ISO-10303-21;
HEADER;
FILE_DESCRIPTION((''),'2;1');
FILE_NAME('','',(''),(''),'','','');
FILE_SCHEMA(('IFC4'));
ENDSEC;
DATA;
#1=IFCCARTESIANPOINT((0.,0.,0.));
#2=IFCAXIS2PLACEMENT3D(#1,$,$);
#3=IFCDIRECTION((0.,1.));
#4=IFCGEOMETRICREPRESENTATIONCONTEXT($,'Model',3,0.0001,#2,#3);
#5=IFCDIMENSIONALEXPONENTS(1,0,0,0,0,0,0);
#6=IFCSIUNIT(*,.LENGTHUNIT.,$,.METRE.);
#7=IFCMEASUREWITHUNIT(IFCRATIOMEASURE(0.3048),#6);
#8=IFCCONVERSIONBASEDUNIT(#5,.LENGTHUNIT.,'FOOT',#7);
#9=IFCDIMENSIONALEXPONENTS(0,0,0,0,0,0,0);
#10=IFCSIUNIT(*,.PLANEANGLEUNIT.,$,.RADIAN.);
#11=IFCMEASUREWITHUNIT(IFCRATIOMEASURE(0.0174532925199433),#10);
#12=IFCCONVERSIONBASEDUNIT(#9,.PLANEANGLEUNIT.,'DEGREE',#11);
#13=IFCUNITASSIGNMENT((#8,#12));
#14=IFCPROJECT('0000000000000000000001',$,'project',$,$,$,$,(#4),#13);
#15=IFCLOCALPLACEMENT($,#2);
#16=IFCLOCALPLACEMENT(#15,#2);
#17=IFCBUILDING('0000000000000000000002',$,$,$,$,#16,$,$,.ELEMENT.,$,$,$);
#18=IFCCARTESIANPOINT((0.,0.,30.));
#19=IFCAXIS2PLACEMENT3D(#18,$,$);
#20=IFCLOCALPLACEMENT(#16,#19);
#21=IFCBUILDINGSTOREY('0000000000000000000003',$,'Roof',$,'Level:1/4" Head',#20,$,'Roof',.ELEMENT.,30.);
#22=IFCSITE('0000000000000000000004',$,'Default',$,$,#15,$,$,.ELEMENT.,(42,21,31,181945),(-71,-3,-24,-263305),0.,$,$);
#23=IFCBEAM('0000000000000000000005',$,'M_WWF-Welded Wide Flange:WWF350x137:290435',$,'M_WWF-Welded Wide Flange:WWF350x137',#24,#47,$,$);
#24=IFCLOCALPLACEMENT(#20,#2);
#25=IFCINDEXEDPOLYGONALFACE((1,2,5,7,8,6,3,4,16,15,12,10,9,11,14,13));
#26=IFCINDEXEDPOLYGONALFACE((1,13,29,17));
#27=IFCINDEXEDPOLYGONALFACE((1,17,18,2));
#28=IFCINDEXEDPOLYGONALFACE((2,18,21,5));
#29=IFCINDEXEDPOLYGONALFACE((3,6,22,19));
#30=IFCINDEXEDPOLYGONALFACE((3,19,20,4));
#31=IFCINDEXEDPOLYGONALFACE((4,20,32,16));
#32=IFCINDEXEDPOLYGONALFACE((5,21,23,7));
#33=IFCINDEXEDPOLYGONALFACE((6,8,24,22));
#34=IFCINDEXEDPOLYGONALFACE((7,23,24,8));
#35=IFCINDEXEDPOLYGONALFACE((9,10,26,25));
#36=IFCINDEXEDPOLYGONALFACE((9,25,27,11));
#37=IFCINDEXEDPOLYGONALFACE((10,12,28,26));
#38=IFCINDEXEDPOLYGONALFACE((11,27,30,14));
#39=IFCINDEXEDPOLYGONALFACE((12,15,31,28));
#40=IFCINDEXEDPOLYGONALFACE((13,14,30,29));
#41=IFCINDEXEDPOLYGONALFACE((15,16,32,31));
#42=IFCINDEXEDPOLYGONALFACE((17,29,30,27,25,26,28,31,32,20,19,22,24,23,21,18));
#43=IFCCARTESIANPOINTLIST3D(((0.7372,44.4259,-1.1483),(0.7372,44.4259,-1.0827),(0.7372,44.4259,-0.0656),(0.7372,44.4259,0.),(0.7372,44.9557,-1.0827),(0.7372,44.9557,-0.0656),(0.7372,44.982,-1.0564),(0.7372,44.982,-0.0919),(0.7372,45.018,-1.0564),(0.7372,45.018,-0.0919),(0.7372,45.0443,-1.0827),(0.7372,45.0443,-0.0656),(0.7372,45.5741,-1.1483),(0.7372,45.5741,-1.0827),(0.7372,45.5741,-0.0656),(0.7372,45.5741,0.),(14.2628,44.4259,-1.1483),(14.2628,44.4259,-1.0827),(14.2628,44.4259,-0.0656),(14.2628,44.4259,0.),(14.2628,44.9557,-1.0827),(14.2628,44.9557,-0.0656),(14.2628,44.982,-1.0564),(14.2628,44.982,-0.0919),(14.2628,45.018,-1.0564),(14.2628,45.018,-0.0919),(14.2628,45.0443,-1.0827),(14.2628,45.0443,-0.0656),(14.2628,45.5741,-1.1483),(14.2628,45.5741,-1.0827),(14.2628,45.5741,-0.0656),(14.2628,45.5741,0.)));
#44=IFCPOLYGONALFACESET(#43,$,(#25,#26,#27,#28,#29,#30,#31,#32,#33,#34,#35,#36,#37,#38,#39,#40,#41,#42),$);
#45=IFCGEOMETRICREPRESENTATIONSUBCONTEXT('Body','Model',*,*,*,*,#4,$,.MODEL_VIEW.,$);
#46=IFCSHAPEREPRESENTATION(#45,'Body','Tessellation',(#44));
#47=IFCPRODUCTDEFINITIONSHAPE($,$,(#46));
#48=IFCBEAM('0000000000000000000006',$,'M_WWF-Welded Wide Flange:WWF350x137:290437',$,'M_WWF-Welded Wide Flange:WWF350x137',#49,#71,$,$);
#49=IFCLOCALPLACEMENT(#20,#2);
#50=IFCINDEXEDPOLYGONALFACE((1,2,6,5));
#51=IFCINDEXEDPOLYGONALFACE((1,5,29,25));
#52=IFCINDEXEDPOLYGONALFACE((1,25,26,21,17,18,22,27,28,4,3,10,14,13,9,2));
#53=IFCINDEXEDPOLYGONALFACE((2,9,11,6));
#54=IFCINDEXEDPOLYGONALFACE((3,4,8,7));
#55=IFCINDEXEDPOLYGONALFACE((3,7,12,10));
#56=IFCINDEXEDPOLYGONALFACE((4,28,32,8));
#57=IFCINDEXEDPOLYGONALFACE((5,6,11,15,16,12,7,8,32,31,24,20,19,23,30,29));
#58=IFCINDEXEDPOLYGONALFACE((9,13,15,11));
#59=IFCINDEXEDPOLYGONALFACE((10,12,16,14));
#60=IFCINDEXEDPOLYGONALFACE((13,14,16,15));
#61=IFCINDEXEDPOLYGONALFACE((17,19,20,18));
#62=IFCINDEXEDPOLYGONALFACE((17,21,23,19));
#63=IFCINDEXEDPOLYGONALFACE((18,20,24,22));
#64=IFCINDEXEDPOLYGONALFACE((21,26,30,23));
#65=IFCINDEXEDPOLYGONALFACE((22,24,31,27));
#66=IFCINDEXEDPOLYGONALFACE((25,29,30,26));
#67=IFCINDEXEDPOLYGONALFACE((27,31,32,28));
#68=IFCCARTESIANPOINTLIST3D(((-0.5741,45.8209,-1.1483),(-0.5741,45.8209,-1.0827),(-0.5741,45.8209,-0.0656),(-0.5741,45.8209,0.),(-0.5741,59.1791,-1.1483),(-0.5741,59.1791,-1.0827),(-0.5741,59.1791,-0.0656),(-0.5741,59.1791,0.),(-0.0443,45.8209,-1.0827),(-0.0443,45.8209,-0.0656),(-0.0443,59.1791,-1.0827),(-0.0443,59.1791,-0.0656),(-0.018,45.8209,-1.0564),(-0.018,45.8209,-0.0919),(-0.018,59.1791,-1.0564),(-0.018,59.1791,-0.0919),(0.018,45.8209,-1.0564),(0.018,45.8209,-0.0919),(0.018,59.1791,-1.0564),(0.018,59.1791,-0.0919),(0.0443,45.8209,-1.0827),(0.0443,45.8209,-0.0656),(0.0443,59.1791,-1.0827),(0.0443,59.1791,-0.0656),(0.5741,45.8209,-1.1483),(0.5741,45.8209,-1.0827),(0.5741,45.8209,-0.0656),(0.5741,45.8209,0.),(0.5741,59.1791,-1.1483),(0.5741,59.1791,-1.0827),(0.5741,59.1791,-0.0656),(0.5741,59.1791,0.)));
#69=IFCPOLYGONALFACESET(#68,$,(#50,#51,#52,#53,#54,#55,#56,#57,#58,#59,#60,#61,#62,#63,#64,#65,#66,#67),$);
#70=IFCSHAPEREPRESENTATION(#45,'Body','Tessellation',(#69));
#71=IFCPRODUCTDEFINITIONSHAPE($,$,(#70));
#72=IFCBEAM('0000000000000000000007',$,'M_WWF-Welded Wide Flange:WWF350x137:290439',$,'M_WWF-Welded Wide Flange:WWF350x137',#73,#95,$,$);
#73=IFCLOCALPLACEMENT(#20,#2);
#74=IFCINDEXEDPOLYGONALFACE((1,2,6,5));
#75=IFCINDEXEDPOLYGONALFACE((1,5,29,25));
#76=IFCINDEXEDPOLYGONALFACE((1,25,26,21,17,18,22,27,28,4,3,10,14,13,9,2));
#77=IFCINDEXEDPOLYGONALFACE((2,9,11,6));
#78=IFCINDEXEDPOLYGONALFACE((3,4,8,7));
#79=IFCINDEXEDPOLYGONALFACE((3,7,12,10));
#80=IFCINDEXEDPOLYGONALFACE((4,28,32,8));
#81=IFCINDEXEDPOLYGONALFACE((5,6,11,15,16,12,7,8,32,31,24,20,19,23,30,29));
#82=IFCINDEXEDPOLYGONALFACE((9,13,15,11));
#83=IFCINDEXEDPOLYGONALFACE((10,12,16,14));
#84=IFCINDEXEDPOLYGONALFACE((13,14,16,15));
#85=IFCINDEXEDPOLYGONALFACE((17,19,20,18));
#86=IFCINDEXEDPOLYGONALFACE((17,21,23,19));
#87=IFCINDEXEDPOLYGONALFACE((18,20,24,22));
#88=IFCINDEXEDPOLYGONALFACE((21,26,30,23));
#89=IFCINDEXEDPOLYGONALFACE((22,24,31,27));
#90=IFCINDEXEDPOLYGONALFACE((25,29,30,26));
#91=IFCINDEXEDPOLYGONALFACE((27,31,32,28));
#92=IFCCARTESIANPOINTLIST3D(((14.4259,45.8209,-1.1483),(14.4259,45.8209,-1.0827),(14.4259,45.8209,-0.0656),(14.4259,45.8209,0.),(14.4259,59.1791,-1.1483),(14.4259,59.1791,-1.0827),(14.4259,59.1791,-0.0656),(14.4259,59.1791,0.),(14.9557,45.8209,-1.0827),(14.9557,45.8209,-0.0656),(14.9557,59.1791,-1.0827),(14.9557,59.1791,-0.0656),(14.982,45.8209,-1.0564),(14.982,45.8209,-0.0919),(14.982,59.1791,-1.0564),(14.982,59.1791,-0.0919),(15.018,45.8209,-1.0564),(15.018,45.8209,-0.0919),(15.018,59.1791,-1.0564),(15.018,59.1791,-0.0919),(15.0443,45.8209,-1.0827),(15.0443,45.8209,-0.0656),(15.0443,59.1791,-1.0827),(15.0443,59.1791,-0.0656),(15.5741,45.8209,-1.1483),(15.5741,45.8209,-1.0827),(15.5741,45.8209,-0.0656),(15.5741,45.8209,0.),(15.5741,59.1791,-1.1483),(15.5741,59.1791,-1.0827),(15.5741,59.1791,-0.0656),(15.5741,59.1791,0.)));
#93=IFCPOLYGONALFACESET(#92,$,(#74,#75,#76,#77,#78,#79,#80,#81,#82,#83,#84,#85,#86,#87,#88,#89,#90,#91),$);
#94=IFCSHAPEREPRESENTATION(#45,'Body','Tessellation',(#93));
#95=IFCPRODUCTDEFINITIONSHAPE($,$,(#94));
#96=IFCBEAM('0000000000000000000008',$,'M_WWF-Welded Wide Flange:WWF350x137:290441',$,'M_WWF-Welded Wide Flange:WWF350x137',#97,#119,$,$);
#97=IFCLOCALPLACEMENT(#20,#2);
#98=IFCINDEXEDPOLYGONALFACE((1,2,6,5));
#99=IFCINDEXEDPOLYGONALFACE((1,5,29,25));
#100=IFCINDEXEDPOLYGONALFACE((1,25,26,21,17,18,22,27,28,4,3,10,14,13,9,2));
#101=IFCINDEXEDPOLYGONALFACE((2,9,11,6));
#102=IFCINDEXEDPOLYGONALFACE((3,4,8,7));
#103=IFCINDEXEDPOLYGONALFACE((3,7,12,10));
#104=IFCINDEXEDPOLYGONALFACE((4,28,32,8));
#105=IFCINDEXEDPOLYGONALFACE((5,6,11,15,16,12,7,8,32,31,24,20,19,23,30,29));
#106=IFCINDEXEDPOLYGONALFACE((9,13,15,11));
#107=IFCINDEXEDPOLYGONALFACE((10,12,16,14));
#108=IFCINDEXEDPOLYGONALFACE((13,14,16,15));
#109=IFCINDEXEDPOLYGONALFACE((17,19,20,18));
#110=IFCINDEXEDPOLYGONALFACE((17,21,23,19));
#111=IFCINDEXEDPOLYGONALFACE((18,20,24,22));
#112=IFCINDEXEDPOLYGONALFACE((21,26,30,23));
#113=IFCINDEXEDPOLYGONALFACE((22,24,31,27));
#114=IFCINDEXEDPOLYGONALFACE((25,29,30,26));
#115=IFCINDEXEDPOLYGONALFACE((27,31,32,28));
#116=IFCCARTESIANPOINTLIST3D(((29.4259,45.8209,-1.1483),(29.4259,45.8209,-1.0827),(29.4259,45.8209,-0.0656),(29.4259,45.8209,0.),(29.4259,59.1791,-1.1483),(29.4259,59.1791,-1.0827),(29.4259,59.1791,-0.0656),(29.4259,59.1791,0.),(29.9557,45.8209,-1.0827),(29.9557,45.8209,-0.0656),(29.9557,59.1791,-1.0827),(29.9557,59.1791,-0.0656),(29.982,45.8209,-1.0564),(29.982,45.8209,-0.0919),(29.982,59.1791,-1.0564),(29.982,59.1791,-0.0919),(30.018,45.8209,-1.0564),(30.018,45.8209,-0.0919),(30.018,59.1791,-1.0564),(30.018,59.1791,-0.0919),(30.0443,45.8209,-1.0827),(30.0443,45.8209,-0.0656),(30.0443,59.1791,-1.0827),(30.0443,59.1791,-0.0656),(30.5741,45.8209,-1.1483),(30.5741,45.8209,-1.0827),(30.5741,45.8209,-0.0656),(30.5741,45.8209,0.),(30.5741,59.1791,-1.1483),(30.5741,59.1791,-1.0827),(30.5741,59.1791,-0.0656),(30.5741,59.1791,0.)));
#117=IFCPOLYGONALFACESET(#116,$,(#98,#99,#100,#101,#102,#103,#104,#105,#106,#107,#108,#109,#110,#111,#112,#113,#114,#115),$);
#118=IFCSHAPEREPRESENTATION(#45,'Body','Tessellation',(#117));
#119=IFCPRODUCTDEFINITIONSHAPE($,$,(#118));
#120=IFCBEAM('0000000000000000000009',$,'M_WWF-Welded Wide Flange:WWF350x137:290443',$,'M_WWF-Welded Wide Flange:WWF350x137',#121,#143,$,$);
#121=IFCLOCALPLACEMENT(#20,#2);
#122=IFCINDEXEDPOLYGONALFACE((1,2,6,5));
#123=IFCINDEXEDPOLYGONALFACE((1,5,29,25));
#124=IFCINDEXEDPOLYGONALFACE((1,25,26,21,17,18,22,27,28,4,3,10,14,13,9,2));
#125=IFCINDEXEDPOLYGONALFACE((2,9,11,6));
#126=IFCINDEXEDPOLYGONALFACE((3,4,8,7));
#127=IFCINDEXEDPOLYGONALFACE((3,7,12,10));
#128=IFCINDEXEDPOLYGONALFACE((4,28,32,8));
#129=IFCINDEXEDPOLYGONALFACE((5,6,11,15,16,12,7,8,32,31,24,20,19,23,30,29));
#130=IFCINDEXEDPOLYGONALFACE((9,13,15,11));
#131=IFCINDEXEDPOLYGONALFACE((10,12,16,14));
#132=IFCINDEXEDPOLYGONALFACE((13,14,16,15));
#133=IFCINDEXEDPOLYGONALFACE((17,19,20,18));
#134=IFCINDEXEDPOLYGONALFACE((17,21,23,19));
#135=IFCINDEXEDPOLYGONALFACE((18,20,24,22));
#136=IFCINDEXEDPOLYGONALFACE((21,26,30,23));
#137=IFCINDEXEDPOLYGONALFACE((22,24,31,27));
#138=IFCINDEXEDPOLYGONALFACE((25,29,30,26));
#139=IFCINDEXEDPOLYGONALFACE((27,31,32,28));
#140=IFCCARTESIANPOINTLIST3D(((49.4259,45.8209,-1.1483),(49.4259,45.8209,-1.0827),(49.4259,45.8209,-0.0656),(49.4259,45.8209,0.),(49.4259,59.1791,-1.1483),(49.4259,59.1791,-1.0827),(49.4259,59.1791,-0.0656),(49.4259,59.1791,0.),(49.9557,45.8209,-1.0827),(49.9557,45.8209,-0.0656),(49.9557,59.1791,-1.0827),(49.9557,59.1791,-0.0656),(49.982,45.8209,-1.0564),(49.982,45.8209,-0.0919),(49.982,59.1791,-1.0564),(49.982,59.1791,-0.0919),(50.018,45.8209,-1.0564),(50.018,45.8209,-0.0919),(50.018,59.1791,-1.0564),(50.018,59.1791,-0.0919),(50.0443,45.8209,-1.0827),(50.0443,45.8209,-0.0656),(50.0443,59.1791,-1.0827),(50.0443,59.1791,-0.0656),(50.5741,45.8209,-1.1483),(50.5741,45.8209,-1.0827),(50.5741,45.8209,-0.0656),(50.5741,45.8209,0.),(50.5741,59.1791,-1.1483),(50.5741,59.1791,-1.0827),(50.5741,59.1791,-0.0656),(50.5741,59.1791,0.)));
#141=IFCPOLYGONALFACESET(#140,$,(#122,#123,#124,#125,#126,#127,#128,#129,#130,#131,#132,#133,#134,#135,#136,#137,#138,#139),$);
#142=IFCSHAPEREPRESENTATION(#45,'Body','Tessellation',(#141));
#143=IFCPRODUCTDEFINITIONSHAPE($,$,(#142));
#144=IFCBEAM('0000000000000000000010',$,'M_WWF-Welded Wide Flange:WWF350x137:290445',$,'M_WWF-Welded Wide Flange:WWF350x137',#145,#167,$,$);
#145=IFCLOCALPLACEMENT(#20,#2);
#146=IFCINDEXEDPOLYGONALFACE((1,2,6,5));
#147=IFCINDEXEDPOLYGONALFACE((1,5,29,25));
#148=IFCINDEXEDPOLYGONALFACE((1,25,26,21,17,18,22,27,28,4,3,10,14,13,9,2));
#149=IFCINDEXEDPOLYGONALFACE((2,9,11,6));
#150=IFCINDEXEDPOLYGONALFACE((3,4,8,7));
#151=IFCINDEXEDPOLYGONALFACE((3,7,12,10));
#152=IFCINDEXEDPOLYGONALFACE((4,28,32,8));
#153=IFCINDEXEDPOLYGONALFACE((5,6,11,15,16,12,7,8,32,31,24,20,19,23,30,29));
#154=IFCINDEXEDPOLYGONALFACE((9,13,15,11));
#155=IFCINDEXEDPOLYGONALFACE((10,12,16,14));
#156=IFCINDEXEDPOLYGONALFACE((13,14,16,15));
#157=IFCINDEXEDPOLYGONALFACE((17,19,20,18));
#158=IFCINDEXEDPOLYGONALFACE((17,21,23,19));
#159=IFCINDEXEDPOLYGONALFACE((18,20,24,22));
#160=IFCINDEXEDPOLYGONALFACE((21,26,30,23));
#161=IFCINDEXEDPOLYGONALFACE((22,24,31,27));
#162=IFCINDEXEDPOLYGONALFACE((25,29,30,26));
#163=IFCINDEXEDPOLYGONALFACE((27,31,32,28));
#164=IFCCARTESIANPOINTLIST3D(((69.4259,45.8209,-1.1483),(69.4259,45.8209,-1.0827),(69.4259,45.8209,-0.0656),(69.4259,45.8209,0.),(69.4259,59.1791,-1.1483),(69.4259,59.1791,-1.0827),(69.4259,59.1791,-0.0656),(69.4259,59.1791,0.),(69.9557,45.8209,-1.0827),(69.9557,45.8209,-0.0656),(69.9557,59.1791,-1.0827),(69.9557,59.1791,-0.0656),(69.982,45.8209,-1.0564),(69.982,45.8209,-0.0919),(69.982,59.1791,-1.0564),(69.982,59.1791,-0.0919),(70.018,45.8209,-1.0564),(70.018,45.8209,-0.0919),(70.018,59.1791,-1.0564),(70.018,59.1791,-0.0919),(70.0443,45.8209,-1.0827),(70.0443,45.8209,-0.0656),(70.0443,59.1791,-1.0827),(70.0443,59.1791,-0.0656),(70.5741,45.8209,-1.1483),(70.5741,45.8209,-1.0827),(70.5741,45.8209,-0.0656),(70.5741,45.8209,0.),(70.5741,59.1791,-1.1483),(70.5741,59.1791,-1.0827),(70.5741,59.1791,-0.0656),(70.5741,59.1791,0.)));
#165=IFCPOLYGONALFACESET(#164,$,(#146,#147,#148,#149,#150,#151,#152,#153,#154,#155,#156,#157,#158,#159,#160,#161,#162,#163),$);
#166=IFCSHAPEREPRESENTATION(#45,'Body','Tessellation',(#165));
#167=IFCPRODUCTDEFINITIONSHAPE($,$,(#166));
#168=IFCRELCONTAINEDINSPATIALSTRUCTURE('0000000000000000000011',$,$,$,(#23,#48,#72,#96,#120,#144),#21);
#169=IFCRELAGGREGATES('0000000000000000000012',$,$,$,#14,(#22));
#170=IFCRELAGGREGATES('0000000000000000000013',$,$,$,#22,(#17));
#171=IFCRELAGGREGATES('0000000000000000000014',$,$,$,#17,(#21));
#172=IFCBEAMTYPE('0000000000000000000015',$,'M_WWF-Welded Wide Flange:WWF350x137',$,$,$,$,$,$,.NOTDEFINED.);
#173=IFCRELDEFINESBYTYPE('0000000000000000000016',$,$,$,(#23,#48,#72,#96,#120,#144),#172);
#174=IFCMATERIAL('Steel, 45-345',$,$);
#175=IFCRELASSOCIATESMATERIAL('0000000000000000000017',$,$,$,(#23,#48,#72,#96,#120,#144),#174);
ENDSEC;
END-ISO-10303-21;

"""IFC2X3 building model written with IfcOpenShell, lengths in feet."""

from ifc_helpers import new_model, entity, si_unit, converted_unit, direction, frame, origin, place, context, subcontext, project, spatial, polyline, outline, extrude, material, type_object, element, save


model = new_model("IFC2X3")

# Units and contexts
model_context = context("Model", 3, precision=0.0001, world=origin(), true_north=direction((0.0, 1.0)))
body_context = subcontext(model_context, "Body", "Model", "MODEL_VIEW")
ifc_project = project(units=[converted_unit("LENGTHUNIT", "FOOT", entity("IfcRatioMeasure", 0.3048), si_unit("LENGTHUNIT", "METRE"), dimensions=[1, 0, 0, 0, 0, 0, 0]), converted_unit("PLANEANGLEUNIT", "DEGREE", entity("IfcRatioMeasure", 0.0174532925199433), si_unit("PLANEANGLEUNIT", "RADIAN"), dimensions=[0, 0, 0, 0, 0, 0, 0])], contexts=[model_context])

# Site, building, storey
site_placement = place(None, origin())
site = spatial("IfcSite", under=ifc_project, at=site_placement, Name="Default", CompositionType="ELEMENT", RefLatitude=(42, 21, 31, 181945), RefLongitude=(-71, -3, -24, -263305), RefElevation=0.0)
building_placement = place(site_placement, origin())
building = spatial("IfcBuilding", under=site, at=building_placement, CompositionType="ELEMENT")
storey_placement = place(building_placement, frame((0.0, 0.0, 30.0)))
storey = spatial("IfcBuildingStorey", under=building, at=storey_placement, Name="Roof", ObjectType="Level:1/4\" Head", LongName="Roof", CompositionType="ELEMENT", Elevation=30.0)

# Beams
ifc_material = material(Name="Steel, 45-345")
beam_type = type_object("IfcBeamType", Name="M_WWF-Welded Wide Flange:WWF350x137", PredefinedType="NOTDEFINED")
beam_1_placement = place(storey_placement, frame((0.0, 45.0, 0.0)))
element("IfcBeam", 1, at=beam_1_placement, inside=storey, type_object=beam_type, material=ifc_material, Name="M_WWF-Welded Wide Flange:WWF350x137:290435", ObjectType="M_WWF-Welded Wide Flange:WWF350x137", context=body_context, shape_type="SweptSolid", body=[
    extrude(outline(polyline([(-0.5741, -0.5741), (-0.5085, -0.5741), (-0.5085, -0.0443), (-0.4823, -0.018), (0.4823, -0.018), (0.5085, -0.0443), (0.5085, -0.5741), (0.5741, -0.5741), (0.5741, 0.5741), (0.5085, 0.5741), (0.5085, 0.0443), (0.4823, 0.018), (-0.4823, 0.018), (-0.5085, 0.0443), (-0.5085, 0.5741), (-0.5741, 0.5741), (-0.5741, -0.5741)])), frame((0.7372, 0.0, -0.5741), z_axis=(1.0, 0.0, 0.0), x_axis=(0.0, 0.0, -1.0)), (0.0, 0.0, 1.0), 13.5256),
])
beam_2_placement = place(storey_placement, frame((0.0, 45.0, 0.0), z_axis=(0.0, 0.0, 1.0), x_axis=(0.0, 1.0, 0.0)))
element("IfcBeam", 2, at=beam_2_placement, inside=storey, type_object=beam_type, material=ifc_material, Name="M_WWF-Welded Wide Flange:WWF350x137:290437", ObjectType="M_WWF-Welded Wide Flange:WWF350x137", context=body_context, shape_type="SweptSolid", body=[
    extrude(outline(polyline([(-0.5741, -0.5741), (-0.5085, -0.5741), (-0.5085, -0.0443), (-0.4823, -0.018), (0.4823, -0.018), (0.5085, -0.0443), (0.5085, -0.5741), (0.5741, -0.5741), (0.5741, 0.5741), (0.5085, 0.5741), (0.5085, 0.0443), (0.4823, 0.018), (-0.4823, 0.018), (-0.5085, 0.0443), (-0.5085, 0.5741), (-0.5741, 0.5741), (-0.5741, -0.5741)])), frame((0.8209, 0.0, -0.5741), z_axis=(1.0, 0.0, 0.0), x_axis=(0.0, 0.0, -1.0)), (0.0, 0.0, 1.0), 13.3583),
])
beam_3_placement = place(storey_placement, frame((15.0, 45.0, 0.0), z_axis=(0.0, 0.0, 1.0), x_axis=(0.0, 1.0, 0.0)))
element("IfcBeam", 3, at=beam_3_placement, inside=storey, type_object=beam_type, material=ifc_material, Name="M_WWF-Welded Wide Flange:WWF350x137:290439", ObjectType="M_WWF-Welded Wide Flange:WWF350x137", context=body_context, shape_type="SweptSolid", body=[
    extrude(outline(polyline([(-0.5741, -0.5741), (-0.5085, -0.5741), (-0.5085, -0.0443), (-0.4823, -0.018), (0.4823, -0.018), (0.5085, -0.0443), (0.5085, -0.5741), (0.5741, -0.5741), (0.5741, 0.5741), (0.5085, 0.5741), (0.5085, 0.0443), (0.4823, 0.018), (-0.4823, 0.018), (-0.5085, 0.0443), (-0.5085, 0.5741), (-0.5741, 0.5741), (-0.5741, -0.5741)])), frame((0.8209, 0.0, -0.5741), z_axis=(1.0, 0.0, 0.0), x_axis=(0.0, 0.0, -1.0)), (0.0, 0.0, 1.0), 13.3583),
])
beam_4_placement = place(storey_placement, frame((30.0, 45.0, 0.0), z_axis=(0.0, 0.0, 1.0), x_axis=(0.0, 1.0, 0.0)))
element("IfcBeam", 4, at=beam_4_placement, inside=storey, type_object=beam_type, material=ifc_material, Name="M_WWF-Welded Wide Flange:WWF350x137:290441", ObjectType="M_WWF-Welded Wide Flange:WWF350x137", context=body_context, shape_type="SweptSolid", body=[
    extrude(outline(polyline([(-0.5741, -0.5741), (-0.5085, -0.5741), (-0.5085, -0.0443), (-0.4823, -0.018), (0.4823, -0.018), (0.5085, -0.0443), (0.5085, -0.5741), (0.5741, -0.5741), (0.5741, 0.5741), (0.5085, 0.5741), (0.5085, 0.0443), (0.4823, 0.018), (-0.4823, 0.018), (-0.5085, 0.0443), (-0.5085, 0.5741), (-0.5741, 0.5741), (-0.5741, -0.5741)])), frame((0.8209, 0.0, -0.5741), z_axis=(1.0, 0.0, 0.0), x_axis=(0.0, 0.0, -1.0)), (0.0, 0.0, 1.0), 13.3583),
])
beam_5_placement = place(storey_placement, frame((50.0, 45.0, 0.0), z_axis=(0.0, 0.0, 1.0), x_axis=(0.0, 1.0, 0.0)))
element("IfcBeam", 5, at=beam_5_placement, inside=storey, type_object=beam_type, material=ifc_material, Name="M_WWF-Welded Wide Flange:WWF350x137:290443", ObjectType="M_WWF-Welded Wide Flange:WWF350x137", context=body_context, shape_type="SweptSolid", body=[
    extrude(outline(polyline([(-0.5741, -0.5741), (-0.5085, -0.5741), (-0.5085, -0.0443), (-0.4823, -0.018), (0.4823, -0.018), (0.5085, -0.0443), (0.5085, -0.5741), (0.5741, -0.5741), (0.5741, 0.5741), (0.5085, 0.5741), (0.5085, 0.0443), (0.4823, 0.018), (-0.4823, 0.018), (-0.5085, 0.0443), (-0.5085, 0.5741), (-0.5741, 0.5741), (-0.5741, -0.5741)])), frame((0.8209, 0.0, -0.5741), z_axis=(1.0, 0.0, 0.0), x_axis=(0.0, 0.0, -1.0)), (0.0, 0.0, 1.0), 13.3583),
])
beam_6_placement = place(storey_placement, frame((70.0, 45.0, 0.0), z_axis=(0.0, 0.0, 1.0), x_axis=(0.0, 1.0, 0.0)))
element("IfcBeam", 6, at=beam_6_placement, inside=storey, type_object=beam_type, material=ifc_material, Name="M_WWF-Welded Wide Flange:WWF350x137:290445", ObjectType="M_WWF-Welded Wide Flange:WWF350x137", context=body_context, shape_type="SweptSolid", body=[
    extrude(outline(polyline([(-0.5741, -0.5741), (-0.5085, -0.5741), (-0.5085, -0.0443), (-0.4823, -0.018), (0.4823, -0.018), (0.5085, -0.0443), (0.5085, -0.5741), (0.5741, -0.5741), (0.5741, 0.5741), (0.5085, 0.5741), (0.5085, 0.0443), (0.4823, 0.018), (-0.4823, 0.018), (-0.5085, 0.0443), (-0.5085, 0.5741), (-0.5741, 0.5741), (-0.5741, -0.5741)])), frame((0.8209, 0.0, -0.5741), z_axis=(1.0, 0.0, 0.0), x_axis=(0.0, 0.0, -1.0)), (0.0, 0.0, 1.0), 13.3583),
])

save(model, "model.ifc")
